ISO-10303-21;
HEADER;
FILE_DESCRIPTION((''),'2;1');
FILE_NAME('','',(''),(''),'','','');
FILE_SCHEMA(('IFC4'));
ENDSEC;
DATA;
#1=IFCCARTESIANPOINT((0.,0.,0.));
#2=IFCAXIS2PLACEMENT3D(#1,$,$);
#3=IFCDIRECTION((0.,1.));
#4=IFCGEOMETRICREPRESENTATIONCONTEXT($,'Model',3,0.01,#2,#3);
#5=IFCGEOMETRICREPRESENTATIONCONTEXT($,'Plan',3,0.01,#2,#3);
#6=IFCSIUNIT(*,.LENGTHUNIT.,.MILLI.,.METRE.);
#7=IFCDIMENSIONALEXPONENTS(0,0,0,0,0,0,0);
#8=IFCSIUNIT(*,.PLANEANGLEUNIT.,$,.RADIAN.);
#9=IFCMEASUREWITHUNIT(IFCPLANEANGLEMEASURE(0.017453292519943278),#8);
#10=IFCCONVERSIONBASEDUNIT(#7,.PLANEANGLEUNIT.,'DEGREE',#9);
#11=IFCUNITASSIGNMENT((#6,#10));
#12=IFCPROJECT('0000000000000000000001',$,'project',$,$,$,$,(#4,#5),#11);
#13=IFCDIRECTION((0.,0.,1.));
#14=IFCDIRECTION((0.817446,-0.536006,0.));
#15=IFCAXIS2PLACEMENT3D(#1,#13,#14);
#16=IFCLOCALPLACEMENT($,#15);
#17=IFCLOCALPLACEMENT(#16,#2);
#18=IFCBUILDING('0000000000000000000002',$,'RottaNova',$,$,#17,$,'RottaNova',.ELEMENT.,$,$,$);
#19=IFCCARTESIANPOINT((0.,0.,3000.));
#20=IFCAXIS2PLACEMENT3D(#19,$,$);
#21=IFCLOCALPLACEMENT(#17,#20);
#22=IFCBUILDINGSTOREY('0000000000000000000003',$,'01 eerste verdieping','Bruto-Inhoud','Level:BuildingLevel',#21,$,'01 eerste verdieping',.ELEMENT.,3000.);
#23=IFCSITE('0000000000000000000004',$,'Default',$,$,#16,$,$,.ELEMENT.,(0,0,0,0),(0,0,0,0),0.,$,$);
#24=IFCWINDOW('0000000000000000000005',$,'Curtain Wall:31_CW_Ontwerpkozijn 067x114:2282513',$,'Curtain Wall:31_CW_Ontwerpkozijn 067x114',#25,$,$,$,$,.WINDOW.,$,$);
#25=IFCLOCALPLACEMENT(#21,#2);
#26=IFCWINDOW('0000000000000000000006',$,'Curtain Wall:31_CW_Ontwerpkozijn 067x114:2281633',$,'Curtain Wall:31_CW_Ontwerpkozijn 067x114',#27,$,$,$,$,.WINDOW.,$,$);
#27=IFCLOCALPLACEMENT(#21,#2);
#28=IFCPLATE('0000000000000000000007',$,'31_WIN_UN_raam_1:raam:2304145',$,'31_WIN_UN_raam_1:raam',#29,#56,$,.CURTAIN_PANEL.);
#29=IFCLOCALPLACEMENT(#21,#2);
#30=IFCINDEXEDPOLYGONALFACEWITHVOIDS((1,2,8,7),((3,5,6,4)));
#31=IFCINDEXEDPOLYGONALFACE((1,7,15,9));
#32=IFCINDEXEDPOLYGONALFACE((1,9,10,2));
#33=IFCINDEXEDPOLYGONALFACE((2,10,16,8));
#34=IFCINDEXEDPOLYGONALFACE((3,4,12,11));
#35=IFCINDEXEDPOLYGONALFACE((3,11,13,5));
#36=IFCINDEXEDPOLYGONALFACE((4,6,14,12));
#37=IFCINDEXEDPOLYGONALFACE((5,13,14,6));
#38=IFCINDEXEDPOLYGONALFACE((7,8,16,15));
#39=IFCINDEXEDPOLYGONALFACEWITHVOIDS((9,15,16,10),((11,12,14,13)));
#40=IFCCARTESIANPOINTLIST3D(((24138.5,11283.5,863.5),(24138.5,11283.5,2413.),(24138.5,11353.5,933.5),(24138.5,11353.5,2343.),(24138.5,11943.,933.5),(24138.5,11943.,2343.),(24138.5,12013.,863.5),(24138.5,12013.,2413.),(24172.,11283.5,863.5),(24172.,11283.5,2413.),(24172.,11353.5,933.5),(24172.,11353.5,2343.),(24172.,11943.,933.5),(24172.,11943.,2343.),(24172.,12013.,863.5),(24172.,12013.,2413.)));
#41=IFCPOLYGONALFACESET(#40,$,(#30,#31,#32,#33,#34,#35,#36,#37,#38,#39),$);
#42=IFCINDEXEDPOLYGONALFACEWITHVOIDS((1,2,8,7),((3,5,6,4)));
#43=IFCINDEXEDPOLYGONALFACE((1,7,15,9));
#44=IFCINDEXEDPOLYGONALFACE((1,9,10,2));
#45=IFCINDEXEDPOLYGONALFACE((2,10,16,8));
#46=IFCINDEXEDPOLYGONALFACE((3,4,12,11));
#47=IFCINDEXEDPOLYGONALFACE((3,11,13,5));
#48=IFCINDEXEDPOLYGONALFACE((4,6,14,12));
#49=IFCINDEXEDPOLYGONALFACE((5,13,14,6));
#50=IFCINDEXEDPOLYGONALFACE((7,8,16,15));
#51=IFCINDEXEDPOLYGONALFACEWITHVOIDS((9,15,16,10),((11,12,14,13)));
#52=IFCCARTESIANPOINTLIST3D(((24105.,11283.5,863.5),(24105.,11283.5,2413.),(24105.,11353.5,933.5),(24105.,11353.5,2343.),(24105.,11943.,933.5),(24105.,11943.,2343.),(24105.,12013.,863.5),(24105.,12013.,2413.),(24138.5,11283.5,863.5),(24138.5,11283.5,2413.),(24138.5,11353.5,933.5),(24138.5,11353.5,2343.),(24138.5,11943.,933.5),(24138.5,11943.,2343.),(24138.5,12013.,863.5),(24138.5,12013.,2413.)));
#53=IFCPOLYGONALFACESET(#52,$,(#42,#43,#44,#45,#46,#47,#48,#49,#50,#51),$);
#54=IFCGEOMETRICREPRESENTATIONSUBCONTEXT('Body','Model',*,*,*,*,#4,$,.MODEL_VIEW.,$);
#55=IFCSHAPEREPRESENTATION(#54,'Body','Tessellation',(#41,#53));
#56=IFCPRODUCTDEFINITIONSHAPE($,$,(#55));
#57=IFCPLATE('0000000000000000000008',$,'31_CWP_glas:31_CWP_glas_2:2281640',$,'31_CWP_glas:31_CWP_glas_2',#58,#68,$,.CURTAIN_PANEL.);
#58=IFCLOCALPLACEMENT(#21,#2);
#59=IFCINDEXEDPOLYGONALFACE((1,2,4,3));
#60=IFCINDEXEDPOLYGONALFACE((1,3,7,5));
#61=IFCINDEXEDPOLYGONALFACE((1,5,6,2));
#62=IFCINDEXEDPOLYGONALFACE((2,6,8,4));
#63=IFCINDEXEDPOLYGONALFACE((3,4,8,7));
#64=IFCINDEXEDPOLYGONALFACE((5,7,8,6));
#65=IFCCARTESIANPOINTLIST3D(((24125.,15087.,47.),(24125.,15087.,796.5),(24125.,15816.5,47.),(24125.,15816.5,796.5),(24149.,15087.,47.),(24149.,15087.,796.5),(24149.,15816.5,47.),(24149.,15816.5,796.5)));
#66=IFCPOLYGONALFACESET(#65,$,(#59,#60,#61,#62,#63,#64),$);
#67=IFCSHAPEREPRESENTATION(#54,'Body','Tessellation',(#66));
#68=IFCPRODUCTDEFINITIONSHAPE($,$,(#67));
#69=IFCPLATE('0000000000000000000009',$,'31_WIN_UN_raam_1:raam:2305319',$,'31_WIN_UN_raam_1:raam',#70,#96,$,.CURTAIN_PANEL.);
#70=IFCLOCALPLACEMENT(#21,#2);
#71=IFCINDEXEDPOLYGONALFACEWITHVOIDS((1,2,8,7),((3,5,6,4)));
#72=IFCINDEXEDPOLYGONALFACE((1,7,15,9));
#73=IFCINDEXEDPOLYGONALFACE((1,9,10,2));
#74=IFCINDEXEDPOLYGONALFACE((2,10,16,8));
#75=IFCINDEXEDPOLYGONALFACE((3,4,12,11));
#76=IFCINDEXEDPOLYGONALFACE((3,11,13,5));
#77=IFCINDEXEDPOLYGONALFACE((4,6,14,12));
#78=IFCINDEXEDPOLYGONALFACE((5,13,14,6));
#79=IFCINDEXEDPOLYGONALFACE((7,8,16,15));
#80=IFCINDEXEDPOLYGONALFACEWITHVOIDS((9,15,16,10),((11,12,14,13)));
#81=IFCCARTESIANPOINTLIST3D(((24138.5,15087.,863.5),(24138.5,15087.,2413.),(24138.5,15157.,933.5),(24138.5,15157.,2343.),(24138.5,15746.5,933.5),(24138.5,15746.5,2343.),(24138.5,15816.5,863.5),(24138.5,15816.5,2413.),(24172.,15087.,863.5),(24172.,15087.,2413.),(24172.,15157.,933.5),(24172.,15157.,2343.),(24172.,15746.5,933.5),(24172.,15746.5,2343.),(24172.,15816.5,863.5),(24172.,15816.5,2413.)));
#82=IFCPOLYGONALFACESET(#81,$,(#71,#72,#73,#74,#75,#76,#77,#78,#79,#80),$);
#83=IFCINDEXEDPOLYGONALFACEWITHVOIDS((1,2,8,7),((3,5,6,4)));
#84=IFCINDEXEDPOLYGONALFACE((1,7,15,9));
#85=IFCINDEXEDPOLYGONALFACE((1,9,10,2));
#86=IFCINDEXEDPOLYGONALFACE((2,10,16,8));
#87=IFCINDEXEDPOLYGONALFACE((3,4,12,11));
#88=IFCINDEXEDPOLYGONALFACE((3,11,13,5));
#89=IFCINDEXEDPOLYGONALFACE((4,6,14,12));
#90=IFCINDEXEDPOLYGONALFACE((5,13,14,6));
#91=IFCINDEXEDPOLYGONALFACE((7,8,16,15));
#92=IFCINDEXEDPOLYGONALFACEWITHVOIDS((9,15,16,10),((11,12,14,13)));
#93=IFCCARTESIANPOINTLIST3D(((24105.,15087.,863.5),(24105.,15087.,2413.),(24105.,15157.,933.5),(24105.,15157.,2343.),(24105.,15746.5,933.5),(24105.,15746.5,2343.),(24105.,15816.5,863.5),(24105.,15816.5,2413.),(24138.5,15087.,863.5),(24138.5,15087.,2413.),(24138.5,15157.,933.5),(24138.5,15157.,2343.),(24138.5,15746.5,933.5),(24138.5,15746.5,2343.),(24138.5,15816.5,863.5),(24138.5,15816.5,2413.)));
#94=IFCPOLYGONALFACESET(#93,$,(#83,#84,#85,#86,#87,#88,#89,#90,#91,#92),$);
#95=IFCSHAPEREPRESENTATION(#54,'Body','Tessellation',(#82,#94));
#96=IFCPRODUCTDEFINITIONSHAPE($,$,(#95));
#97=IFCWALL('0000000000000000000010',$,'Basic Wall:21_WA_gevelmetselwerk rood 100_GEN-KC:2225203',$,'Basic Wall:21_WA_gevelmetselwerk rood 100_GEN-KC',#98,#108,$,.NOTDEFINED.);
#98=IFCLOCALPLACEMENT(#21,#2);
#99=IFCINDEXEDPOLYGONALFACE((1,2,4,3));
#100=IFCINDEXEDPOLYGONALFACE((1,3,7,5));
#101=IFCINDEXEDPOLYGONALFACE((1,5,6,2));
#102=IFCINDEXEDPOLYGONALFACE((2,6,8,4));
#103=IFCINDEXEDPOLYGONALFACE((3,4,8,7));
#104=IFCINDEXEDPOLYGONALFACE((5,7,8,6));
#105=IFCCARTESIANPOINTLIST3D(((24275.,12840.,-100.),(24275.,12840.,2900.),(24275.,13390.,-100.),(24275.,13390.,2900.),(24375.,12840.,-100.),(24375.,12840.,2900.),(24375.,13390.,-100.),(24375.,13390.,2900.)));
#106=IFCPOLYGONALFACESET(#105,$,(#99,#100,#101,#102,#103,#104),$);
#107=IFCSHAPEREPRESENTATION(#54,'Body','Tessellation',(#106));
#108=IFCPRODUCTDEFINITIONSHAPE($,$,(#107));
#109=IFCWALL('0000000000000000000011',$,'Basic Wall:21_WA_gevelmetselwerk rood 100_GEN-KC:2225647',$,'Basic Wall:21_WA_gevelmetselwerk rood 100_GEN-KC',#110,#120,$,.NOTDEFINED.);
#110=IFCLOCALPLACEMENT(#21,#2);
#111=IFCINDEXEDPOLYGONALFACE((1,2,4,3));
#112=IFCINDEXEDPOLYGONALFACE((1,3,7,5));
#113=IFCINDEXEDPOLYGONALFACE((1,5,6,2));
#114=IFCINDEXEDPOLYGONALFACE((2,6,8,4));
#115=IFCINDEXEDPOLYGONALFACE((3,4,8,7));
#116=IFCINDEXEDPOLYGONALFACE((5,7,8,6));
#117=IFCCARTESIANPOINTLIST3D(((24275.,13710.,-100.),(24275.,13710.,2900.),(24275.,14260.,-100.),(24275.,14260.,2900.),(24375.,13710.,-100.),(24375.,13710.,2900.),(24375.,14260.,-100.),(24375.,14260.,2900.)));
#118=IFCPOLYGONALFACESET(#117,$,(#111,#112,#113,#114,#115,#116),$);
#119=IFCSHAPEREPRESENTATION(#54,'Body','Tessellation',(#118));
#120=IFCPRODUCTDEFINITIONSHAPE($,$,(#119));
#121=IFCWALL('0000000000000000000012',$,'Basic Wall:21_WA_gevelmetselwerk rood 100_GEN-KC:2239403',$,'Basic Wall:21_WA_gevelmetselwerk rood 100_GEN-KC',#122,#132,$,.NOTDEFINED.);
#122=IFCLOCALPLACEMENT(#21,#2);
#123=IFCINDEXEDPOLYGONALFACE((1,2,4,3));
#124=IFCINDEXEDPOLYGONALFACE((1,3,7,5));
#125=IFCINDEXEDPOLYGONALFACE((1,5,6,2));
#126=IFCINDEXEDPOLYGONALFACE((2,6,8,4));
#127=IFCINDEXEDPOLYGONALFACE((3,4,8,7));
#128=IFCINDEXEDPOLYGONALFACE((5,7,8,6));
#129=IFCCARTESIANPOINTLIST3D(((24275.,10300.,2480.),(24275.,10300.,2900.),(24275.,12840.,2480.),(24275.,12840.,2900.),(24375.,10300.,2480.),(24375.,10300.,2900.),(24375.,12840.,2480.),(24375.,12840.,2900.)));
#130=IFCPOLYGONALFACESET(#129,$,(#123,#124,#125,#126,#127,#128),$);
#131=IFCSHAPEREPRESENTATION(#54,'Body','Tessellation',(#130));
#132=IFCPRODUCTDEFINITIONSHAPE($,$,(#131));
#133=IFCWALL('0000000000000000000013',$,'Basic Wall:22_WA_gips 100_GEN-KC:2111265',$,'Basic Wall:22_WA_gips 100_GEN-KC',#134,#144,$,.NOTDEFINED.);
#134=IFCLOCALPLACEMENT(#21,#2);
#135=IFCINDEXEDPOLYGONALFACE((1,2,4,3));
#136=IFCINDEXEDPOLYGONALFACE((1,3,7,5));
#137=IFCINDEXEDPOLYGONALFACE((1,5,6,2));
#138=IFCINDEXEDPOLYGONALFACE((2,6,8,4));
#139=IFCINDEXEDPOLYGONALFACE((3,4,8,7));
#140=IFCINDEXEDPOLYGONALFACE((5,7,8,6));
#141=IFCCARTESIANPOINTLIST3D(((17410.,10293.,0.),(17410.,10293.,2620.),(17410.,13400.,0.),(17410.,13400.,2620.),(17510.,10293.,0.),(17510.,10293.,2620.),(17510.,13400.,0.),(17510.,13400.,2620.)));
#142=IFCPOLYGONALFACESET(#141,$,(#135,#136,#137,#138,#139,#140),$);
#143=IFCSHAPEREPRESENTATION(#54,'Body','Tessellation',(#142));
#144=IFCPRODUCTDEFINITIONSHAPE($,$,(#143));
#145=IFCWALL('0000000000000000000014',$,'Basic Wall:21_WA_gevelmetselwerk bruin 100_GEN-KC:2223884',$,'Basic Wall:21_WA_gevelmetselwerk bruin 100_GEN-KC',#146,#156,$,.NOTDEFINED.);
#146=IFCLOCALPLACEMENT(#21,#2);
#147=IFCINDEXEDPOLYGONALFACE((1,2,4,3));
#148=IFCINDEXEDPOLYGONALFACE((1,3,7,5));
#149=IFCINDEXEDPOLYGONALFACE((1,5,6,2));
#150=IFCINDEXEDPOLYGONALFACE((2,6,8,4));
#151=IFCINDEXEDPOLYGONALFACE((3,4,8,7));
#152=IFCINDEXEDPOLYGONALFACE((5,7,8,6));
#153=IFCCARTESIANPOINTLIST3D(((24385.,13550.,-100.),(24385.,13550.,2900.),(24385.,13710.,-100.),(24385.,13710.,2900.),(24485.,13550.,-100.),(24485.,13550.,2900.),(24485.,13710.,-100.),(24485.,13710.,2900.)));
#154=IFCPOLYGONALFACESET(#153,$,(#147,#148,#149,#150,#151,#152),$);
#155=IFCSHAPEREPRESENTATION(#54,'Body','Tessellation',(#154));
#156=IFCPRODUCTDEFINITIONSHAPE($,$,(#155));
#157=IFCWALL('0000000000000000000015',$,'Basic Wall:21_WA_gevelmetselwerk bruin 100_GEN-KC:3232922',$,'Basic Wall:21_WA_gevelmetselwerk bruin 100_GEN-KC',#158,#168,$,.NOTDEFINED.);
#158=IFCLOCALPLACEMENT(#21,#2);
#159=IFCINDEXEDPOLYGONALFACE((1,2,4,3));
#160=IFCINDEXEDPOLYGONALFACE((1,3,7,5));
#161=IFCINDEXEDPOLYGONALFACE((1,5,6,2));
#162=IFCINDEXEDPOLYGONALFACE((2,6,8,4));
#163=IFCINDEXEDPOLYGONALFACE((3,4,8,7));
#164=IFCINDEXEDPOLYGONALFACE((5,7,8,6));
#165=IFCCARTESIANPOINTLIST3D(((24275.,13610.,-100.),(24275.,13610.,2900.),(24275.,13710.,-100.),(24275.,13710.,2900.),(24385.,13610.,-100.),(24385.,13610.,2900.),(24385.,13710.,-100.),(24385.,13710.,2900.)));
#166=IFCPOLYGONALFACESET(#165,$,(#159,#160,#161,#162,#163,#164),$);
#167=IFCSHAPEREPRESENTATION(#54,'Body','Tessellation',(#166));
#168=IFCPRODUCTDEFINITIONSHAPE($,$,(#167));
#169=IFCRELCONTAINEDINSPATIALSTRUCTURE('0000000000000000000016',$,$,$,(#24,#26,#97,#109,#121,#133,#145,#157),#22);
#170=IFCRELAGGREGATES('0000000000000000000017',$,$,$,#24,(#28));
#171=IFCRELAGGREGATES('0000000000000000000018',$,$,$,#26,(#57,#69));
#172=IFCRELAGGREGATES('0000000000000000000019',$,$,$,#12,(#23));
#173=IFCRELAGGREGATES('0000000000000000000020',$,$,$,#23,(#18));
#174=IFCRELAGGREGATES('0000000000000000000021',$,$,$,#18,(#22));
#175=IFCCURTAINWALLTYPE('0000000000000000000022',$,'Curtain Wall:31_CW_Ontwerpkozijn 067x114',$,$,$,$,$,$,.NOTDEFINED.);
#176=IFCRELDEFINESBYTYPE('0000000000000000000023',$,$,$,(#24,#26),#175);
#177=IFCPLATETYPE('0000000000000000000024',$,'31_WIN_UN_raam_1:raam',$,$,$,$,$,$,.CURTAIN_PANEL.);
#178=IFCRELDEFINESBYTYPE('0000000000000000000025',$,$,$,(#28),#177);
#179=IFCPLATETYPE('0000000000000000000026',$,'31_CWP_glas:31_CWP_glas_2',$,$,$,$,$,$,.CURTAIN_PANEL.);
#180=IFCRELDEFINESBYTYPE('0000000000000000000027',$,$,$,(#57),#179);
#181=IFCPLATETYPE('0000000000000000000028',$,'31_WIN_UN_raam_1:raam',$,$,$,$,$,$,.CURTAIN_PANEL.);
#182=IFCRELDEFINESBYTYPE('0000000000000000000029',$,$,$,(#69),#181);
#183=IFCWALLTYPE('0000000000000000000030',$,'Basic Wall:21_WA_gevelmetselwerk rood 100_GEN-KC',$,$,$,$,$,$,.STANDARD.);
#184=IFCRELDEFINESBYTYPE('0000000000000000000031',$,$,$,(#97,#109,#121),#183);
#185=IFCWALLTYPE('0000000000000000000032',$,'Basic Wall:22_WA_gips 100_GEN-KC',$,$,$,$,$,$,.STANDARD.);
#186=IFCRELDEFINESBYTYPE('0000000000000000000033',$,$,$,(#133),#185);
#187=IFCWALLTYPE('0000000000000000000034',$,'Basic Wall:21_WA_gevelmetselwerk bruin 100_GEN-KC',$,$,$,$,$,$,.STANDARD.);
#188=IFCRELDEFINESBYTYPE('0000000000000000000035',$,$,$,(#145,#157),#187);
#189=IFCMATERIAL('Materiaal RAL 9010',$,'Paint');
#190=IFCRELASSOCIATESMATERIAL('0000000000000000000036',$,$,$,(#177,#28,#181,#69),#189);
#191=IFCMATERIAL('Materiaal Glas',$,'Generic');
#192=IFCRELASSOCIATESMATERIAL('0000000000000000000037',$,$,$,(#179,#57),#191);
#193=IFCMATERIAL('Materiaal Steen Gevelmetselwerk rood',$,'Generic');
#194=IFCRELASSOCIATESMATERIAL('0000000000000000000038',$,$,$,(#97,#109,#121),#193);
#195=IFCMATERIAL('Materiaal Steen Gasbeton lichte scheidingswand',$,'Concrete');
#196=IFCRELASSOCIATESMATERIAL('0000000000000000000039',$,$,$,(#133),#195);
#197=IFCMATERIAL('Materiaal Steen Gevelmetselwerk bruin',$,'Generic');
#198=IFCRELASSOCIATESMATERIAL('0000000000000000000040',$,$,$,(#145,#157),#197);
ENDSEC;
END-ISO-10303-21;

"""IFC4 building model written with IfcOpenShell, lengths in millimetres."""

from ifc_helpers import new_model, entity, si_unit, converted_unit, direction, frame, origin, place, context, subcontext, project, spatial, indexed_curve, outline, extrude, source, transform, mapped, material, type_object, type_shapes, element, aggregate, save


model = new_model("IFC4")

# Units and contexts
model_context = context("Model", 3, precision=0.01, world=origin(), true_north=direction((0.0, 1.0)))
plan_context = context("Plan", 3, precision=0.01, world=origin(), true_north=direction((0.0, 1.0)))
body_context = subcontext(model_context, "Body", "Model", "MODEL_VIEW")
ifc_project = project(units=[si_unit("LENGTHUNIT", "METRE", prefix="MILLI"), converted_unit("PLANEANGLEUNIT", "DEGREE", entity("IfcPlaneAngleMeasure", 0.017453292519943278), si_unit("PLANEANGLEUNIT", "RADIAN"), dimensions=[0, 0, 0, 0, 0, 0, 0])], contexts=[model_context, plan_context])

# Site, building, storey
site_placement = place(None, frame((0.0, 0.0, 0.0), z_axis=(0.0, 0.0, 1.0), x_axis=(0.817446, -0.536006, 0.0)))
site = spatial("IfcSite", under=ifc_project, at=site_placement, Name="Default", CompositionType="ELEMENT", RefLatitude=(0, 0, 0, 0), RefLongitude=(0, 0, 0, 0), RefElevation=0.0)
building_placement = place(site_placement, origin())
building = spatial("IfcBuilding", under=site, at=building_placement, Name="RottaNova", LongName="RottaNova", CompositionType="ELEMENT")
storey_placement = place(building_placement, frame((0.0, 0.0, 3000.0)))
storey = spatial("IfcBuildingStorey", under=building, at=storey_placement, Name="01 eerste verdieping", Description="Bruto-Inhoud", ObjectType="Level:BuildingLevel", LongName="01 eerste verdieping", CompositionType="ELEMENT", Elevation=3000.0)

# Window
curtain_wall_type = type_object("IfcCurtainWallType", Name="Curtain Wall:31_CW_Ontwerpkozijn 067x114", PredefinedType="NOTDEFINED")
window_1_placement = place(storey_placement, frame((0.0, 0.0, -3000.0)))
window_1 = element("IfcWindow", 1, at=window_1_placement, inside=storey, type_object=curtain_wall_type, Name="Curtain Wall:31_CW_Ontwerpkozijn 067x114:2282513", ObjectType="Curtain Wall:31_CW_Ontwerpkozijn 067x114", PredefinedType="WINDOW")

# Window
window_2_placement = place(storey_placement, frame((0.0, 0.0, -3000.0)))
window_2 = element("IfcWindow", 2, at=window_2_placement, inside=storey, type_object=curtain_wall_type, Name="Curtain Wall:31_CW_Ontwerpkozijn 067x114:2281633", ObjectType="Curtain Wall:31_CW_Ontwerpkozijn 067x114", PredefinedType="WINDOW")

# Plates
ifc_material_1 = material(Name="Materiaal Glas", Category="Generic")
ifc_material_2 = material(Name="Materiaal RAL 9010", Category="Paint")
plate_type_1 = type_object("IfcPlateType", Name="31_WIN_UN_raam_1:raam", PredefinedType="CURTAIN_PANEL", material=ifc_material_2)
shared_shape_1 = source(origin(), body_context, "Body", "SweptSolid", [
    extrude(outline(indexed_curve([(-364.7, -774.7), (364.7, -774.7), (364.7, 774.7), (-364.7, 774.7), (-364.7, -774.7)], self_intersect=False), holes=[indexed_curve([(-294.7, 704.7), (294.7, 704.7), (294.7, -704.8), (-294.7, -704.8), (-294.7, 704.7)], self_intersect=False)]), frame((0.0, -92.0, 774.8), z_axis=(0.0, 1.0, 0.0), x_axis=(1.0, 0.0, 0.0)), (0.0, 0.0, 1.0), 33.5),
    extrude(outline(indexed_curve([(-364.7, -774.7), (364.7, -774.7), (364.7, 774.7), (-364.7, 774.7), (-364.7, -774.7)], self_intersect=False), holes=[indexed_curve([(-294.7, 704.7), (294.7, 704.7), (294.7, -704.8), (-294.7, -704.8), (-294.7, 704.7)], self_intersect=False)]), frame((0.0, -58.5, 774.8), z_axis=(0.0, 1.0, 0.0), x_axis=(1.0, 0.0, 0.0)), (0.0, 0.0, 1.0), 33.5),
])
type_shapes(plate_type_1, [shared_shape_1])
plate_1_placement = place(window_1_placement, frame((24080.0, 11648.2, 3863.5), z_axis=(0.0, 0.0, 1.0), x_axis=(0.0, 1.0, 0.0)))
plate_1 = element("IfcPlate", 3, at=plate_1_placement, type_object=plate_type_1, material=ifc_material_2, Name="31_WIN_UN_raam_1:raam:2304145", ObjectType="31_WIN_UN_raam_1:raam", PredefinedType="CURTAIN_PANEL", context=body_context, shape_type="MappedRepresentation", body=[
    mapped(shared_shape_1, transform((0.0, 0.0, 0.0), scale=1.0)),
])
aggregate(window_1, [plate_1])
plate_type_2 = type_object("IfcPlateType", Name="31_CWP_glas:31_CWP_glas_2", PredefinedType="CURTAIN_PANEL", material=ifc_material_1)
shared_shape_2 = source(origin(), body_context, "Body", "SweptSolid", [
    extrude(outline(indexed_curve([(-12.0, -364.7), (12.0, -364.7), (12.0, 364.7), (-12.0, 364.7), (-12.0, -364.7)], self_intersect=False)), frame((0.0, 57.0, 0.0), z_axis=(0.0, 0.0, 1.0), x_axis=(0.0, 1.0, 0.0)), (0.0, 0.0, 1.0), 749.5),
])
type_shapes(plate_type_2, [shared_shape_2])
plate_2_placement = place(window_2_placement, frame((24080.0, 15451.8, 3047.0), z_axis=(0.0, 0.0, 1.0), x_axis=(0.0, -1.0, 0.0)))
plate_2 = element("IfcPlate", 4, at=plate_2_placement, type_object=plate_type_2, material=ifc_material_1, Name="31_CWP_glas:31_CWP_glas_2:2281640", ObjectType="31_CWP_glas:31_CWP_glas_2", PredefinedType="CURTAIN_PANEL", context=body_context, shape_type="MappedRepresentation", body=[
    mapped(shared_shape_2, transform((0.0, 0.0, 0.0), scale=1.0)),
])
plate_type_3 = type_object("IfcPlateType", Name="31_WIN_UN_raam_1:raam", PredefinedType="CURTAIN_PANEL", material=ifc_material_2)
shared_shape_3 = source(origin(), body_context, "Body", "SweptSolid", [
    extrude(outline(indexed_curve([(-364.7, -774.7), (364.7, -774.7), (364.7, 774.7), (-364.7, 774.7), (-364.7, -774.7)], self_intersect=False), holes=[indexed_curve([(-294.7, 704.7), (294.7, 704.7), (294.7, -704.8), (-294.7, -704.8), (-294.7, 704.7)], self_intersect=False)]), frame((0.0, 58.5, 774.8), z_axis=(0.0, 1.0, 0.0), x_axis=(1.0, 0.0, 0.0)), (0.0, 0.0, 1.0), 33.5),
    extrude(outline(indexed_curve([(-364.7, -774.7), (364.7, -774.7), (364.7, 774.7), (-364.7, 774.7), (-364.7, -774.7)], self_intersect=False), holes=[indexed_curve([(-294.7, 704.7), (294.7, 704.7), (294.7, -704.8), (-294.7, -704.8), (-294.7, 704.7)], self_intersect=False)]), frame((0.0, 25.0, 774.8), z_axis=(0.0, 1.0, 0.0), x_axis=(1.0, 0.0, 0.0)), (0.0, 0.0, 1.0), 33.5),
])
type_shapes(plate_type_3, [shared_shape_3])
plate_3_placement = place(window_2_placement, frame((24080.0, 15451.8, 3863.5), z_axis=(0.0, 0.0, 1.0), x_axis=(0.0, -1.0, 0.0)))
plate_3 = element("IfcPlate", 5, at=plate_3_placement, type_object=plate_type_3, material=ifc_material_2, Name="31_WIN_UN_raam_1:raam:2305319", ObjectType="31_WIN_UN_raam_1:raam", PredefinedType="CURTAIN_PANEL", context=body_context, shape_type="MappedRepresentation", body=[
    mapped(shared_shape_3, transform((0.0, 0.0, 0.0), scale=1.0)),
])
aggregate(window_2, [plate_2, plate_3])

# Walls
ifc_material_3 = material(Name="Materiaal Steen Gevelmetselwerk rood", Category="Generic")
wall_type_1 = type_object("IfcWallType", Name="Basic Wall:21_WA_gevelmetselwerk rood 100_GEN-KC", PredefinedType="STANDARD")
wall_1_placement = place(storey_placement, frame((24325.0, 12840.0, -100.0), z_axis=(0.0, 0.0, 1.0), x_axis=(0.0, 1.0, 0.0)))
element("IfcWall", 6, at=wall_1_placement, inside=storey, type_object=wall_type_1, material=ifc_material_3, Name="Basic Wall:21_WA_gevelmetselwerk rood 100_GEN-KC:2225203", ObjectType="Basic Wall:21_WA_gevelmetselwerk rood 100_GEN-KC", PredefinedType="NOTDEFINED", context=body_context, shape_type="SweptSolid", body=[
    extrude(outline(indexed_curve([(550.0, 50.0), (0.0, 50.0), (0.0, -50.0), (550.0, -50.0), (550.0, 50.0)], self_intersect=False)), origin(), (0.0, 0.0, 1.0), 3000.0),
])
wall_2_placement = place(storey_placement, frame((24325.0, 13710.0, -100.0), z_axis=(0.0, 0.0, 1.0), x_axis=(0.0, 1.0, 0.0)))
element("IfcWall", 7, at=wall_2_placement, inside=storey, type_object=wall_type_1, material=ifc_material_3, Name="Basic Wall:21_WA_gevelmetselwerk rood 100_GEN-KC:2225647", ObjectType="Basic Wall:21_WA_gevelmetselwerk rood 100_GEN-KC", PredefinedType="NOTDEFINED", context=body_context, shape_type="SweptSolid", body=[
    extrude(outline(indexed_curve([(550.0, 50.0), (0.0, 50.0), (0.0, -50.0), (550.0, -50.0), (550.0, 50.0)], self_intersect=False)), origin(), (0.0, 0.0, 1.0), 3000.0),
])
wall_3_placement = place(storey_placement, frame((24325.0, 12840.0, 2480.0), z_axis=(0.0, 0.0, 1.0), x_axis=(0.0, -1.0, 0.0)))
element("IfcWall", 8, at=wall_3_placement, inside=storey, type_object=wall_type_1, material=ifc_material_3, Name="Basic Wall:21_WA_gevelmetselwerk rood 100_GEN-KC:2239403", ObjectType="Basic Wall:21_WA_gevelmetselwerk rood 100_GEN-KC", PredefinedType="NOTDEFINED", context=body_context, shape_type="SweptSolid", body=[
    extrude(outline(indexed_curve([(2540.0, 50.0), (0.0, 50.0), (0.0, -50.0), (2540.0, -50.0), (2540.0, 50.0)], self_intersect=False)), origin(), (0.0, 0.0, 1.0), 420.0),
])
ifc_material_4 = material(Name="Materiaal Steen Gasbeton lichte scheidingswand", Category="Concrete")
wall_type_2 = type_object("IfcWallType", Name="Basic Wall:22_WA_gips 100_GEN-KC", PredefinedType="STANDARD")
wall_4_placement = place(storey_placement, frame((17460.0, 13400.0, 0.0), z_axis=(0.0, 0.0, 1.0), x_axis=(0.0, -1.0, 0.0)))
element("IfcWall", 9, at=wall_4_placement, inside=storey, type_object=wall_type_2, material=ifc_material_4, Name="Basic Wall:22_WA_gips 100_GEN-KC:2111265", ObjectType="Basic Wall:22_WA_gips 100_GEN-KC", PredefinedType="NOTDEFINED", context=body_context, shape_type="SweptSolid", body=[
    extrude(outline(indexed_curve([(3107.0, 50.0), (0.0, 50.0), (0.0, -50.0), (3107.0, -50.0), (3107.0, 50.0)], self_intersect=False)), origin(), (0.0, 0.0, 1.0), 2620.0),
])
ifc_material_5 = material(Name="Materiaal Steen Gevelmetselwerk bruin", Category="Generic")
wall_type_3 = type_object("IfcWallType", Name="Basic Wall:21_WA_gevelmetselwerk bruin 100_GEN-KC", PredefinedType="STANDARD")
wall_5_placement = place(storey_placement, frame((24435.0, 13710.0, -100.0), z_axis=(0.0, 0.0, 1.0), x_axis=(0.0, -1.0, 0.0)))
element("IfcWall", 10, at=wall_5_placement, inside=storey, type_object=wall_type_3, material=ifc_material_5, Name="Basic Wall:21_WA_gevelmetselwerk bruin 100_GEN-KC:2223884", ObjectType="Basic Wall:21_WA_gevelmetselwerk bruin 100_GEN-KC", PredefinedType="NOTDEFINED", context=body_context, shape_type="SweptSolid", body=[
    extrude(outline(indexed_curve([(160.0, 50.0), (0.0, 50.0), (0.0, -50.0), (160.0, -50.0), (160.0, 50.0)], self_intersect=False)), origin(), (0.0, 0.0, 1.0), 3000.0),
])
wall_6_placement = place(storey_placement, frame((24275.0, 13660.0, -100.0)))
element("IfcWall", 11, at=wall_6_placement, inside=storey, type_object=wall_type_3, material=ifc_material_5, Name="Basic Wall:21_WA_gevelmetselwerk bruin 100_GEN-KC:3232922", ObjectType="Basic Wall:21_WA_gevelmetselwerk bruin 100_GEN-KC", PredefinedType="NOTDEFINED", context=body_context, shape_type="SweptSolid", body=[
    extrude(outline(indexed_curve([(110.0, 50.0), (0.0, 50.0), (0.0, -50.0), (110.0, -50.0), (110.0, 50.0)], self_intersect=False)), origin(), (0.0, 0.0, 1.0), 3000.0),
])

save(model, "model.ifc")
